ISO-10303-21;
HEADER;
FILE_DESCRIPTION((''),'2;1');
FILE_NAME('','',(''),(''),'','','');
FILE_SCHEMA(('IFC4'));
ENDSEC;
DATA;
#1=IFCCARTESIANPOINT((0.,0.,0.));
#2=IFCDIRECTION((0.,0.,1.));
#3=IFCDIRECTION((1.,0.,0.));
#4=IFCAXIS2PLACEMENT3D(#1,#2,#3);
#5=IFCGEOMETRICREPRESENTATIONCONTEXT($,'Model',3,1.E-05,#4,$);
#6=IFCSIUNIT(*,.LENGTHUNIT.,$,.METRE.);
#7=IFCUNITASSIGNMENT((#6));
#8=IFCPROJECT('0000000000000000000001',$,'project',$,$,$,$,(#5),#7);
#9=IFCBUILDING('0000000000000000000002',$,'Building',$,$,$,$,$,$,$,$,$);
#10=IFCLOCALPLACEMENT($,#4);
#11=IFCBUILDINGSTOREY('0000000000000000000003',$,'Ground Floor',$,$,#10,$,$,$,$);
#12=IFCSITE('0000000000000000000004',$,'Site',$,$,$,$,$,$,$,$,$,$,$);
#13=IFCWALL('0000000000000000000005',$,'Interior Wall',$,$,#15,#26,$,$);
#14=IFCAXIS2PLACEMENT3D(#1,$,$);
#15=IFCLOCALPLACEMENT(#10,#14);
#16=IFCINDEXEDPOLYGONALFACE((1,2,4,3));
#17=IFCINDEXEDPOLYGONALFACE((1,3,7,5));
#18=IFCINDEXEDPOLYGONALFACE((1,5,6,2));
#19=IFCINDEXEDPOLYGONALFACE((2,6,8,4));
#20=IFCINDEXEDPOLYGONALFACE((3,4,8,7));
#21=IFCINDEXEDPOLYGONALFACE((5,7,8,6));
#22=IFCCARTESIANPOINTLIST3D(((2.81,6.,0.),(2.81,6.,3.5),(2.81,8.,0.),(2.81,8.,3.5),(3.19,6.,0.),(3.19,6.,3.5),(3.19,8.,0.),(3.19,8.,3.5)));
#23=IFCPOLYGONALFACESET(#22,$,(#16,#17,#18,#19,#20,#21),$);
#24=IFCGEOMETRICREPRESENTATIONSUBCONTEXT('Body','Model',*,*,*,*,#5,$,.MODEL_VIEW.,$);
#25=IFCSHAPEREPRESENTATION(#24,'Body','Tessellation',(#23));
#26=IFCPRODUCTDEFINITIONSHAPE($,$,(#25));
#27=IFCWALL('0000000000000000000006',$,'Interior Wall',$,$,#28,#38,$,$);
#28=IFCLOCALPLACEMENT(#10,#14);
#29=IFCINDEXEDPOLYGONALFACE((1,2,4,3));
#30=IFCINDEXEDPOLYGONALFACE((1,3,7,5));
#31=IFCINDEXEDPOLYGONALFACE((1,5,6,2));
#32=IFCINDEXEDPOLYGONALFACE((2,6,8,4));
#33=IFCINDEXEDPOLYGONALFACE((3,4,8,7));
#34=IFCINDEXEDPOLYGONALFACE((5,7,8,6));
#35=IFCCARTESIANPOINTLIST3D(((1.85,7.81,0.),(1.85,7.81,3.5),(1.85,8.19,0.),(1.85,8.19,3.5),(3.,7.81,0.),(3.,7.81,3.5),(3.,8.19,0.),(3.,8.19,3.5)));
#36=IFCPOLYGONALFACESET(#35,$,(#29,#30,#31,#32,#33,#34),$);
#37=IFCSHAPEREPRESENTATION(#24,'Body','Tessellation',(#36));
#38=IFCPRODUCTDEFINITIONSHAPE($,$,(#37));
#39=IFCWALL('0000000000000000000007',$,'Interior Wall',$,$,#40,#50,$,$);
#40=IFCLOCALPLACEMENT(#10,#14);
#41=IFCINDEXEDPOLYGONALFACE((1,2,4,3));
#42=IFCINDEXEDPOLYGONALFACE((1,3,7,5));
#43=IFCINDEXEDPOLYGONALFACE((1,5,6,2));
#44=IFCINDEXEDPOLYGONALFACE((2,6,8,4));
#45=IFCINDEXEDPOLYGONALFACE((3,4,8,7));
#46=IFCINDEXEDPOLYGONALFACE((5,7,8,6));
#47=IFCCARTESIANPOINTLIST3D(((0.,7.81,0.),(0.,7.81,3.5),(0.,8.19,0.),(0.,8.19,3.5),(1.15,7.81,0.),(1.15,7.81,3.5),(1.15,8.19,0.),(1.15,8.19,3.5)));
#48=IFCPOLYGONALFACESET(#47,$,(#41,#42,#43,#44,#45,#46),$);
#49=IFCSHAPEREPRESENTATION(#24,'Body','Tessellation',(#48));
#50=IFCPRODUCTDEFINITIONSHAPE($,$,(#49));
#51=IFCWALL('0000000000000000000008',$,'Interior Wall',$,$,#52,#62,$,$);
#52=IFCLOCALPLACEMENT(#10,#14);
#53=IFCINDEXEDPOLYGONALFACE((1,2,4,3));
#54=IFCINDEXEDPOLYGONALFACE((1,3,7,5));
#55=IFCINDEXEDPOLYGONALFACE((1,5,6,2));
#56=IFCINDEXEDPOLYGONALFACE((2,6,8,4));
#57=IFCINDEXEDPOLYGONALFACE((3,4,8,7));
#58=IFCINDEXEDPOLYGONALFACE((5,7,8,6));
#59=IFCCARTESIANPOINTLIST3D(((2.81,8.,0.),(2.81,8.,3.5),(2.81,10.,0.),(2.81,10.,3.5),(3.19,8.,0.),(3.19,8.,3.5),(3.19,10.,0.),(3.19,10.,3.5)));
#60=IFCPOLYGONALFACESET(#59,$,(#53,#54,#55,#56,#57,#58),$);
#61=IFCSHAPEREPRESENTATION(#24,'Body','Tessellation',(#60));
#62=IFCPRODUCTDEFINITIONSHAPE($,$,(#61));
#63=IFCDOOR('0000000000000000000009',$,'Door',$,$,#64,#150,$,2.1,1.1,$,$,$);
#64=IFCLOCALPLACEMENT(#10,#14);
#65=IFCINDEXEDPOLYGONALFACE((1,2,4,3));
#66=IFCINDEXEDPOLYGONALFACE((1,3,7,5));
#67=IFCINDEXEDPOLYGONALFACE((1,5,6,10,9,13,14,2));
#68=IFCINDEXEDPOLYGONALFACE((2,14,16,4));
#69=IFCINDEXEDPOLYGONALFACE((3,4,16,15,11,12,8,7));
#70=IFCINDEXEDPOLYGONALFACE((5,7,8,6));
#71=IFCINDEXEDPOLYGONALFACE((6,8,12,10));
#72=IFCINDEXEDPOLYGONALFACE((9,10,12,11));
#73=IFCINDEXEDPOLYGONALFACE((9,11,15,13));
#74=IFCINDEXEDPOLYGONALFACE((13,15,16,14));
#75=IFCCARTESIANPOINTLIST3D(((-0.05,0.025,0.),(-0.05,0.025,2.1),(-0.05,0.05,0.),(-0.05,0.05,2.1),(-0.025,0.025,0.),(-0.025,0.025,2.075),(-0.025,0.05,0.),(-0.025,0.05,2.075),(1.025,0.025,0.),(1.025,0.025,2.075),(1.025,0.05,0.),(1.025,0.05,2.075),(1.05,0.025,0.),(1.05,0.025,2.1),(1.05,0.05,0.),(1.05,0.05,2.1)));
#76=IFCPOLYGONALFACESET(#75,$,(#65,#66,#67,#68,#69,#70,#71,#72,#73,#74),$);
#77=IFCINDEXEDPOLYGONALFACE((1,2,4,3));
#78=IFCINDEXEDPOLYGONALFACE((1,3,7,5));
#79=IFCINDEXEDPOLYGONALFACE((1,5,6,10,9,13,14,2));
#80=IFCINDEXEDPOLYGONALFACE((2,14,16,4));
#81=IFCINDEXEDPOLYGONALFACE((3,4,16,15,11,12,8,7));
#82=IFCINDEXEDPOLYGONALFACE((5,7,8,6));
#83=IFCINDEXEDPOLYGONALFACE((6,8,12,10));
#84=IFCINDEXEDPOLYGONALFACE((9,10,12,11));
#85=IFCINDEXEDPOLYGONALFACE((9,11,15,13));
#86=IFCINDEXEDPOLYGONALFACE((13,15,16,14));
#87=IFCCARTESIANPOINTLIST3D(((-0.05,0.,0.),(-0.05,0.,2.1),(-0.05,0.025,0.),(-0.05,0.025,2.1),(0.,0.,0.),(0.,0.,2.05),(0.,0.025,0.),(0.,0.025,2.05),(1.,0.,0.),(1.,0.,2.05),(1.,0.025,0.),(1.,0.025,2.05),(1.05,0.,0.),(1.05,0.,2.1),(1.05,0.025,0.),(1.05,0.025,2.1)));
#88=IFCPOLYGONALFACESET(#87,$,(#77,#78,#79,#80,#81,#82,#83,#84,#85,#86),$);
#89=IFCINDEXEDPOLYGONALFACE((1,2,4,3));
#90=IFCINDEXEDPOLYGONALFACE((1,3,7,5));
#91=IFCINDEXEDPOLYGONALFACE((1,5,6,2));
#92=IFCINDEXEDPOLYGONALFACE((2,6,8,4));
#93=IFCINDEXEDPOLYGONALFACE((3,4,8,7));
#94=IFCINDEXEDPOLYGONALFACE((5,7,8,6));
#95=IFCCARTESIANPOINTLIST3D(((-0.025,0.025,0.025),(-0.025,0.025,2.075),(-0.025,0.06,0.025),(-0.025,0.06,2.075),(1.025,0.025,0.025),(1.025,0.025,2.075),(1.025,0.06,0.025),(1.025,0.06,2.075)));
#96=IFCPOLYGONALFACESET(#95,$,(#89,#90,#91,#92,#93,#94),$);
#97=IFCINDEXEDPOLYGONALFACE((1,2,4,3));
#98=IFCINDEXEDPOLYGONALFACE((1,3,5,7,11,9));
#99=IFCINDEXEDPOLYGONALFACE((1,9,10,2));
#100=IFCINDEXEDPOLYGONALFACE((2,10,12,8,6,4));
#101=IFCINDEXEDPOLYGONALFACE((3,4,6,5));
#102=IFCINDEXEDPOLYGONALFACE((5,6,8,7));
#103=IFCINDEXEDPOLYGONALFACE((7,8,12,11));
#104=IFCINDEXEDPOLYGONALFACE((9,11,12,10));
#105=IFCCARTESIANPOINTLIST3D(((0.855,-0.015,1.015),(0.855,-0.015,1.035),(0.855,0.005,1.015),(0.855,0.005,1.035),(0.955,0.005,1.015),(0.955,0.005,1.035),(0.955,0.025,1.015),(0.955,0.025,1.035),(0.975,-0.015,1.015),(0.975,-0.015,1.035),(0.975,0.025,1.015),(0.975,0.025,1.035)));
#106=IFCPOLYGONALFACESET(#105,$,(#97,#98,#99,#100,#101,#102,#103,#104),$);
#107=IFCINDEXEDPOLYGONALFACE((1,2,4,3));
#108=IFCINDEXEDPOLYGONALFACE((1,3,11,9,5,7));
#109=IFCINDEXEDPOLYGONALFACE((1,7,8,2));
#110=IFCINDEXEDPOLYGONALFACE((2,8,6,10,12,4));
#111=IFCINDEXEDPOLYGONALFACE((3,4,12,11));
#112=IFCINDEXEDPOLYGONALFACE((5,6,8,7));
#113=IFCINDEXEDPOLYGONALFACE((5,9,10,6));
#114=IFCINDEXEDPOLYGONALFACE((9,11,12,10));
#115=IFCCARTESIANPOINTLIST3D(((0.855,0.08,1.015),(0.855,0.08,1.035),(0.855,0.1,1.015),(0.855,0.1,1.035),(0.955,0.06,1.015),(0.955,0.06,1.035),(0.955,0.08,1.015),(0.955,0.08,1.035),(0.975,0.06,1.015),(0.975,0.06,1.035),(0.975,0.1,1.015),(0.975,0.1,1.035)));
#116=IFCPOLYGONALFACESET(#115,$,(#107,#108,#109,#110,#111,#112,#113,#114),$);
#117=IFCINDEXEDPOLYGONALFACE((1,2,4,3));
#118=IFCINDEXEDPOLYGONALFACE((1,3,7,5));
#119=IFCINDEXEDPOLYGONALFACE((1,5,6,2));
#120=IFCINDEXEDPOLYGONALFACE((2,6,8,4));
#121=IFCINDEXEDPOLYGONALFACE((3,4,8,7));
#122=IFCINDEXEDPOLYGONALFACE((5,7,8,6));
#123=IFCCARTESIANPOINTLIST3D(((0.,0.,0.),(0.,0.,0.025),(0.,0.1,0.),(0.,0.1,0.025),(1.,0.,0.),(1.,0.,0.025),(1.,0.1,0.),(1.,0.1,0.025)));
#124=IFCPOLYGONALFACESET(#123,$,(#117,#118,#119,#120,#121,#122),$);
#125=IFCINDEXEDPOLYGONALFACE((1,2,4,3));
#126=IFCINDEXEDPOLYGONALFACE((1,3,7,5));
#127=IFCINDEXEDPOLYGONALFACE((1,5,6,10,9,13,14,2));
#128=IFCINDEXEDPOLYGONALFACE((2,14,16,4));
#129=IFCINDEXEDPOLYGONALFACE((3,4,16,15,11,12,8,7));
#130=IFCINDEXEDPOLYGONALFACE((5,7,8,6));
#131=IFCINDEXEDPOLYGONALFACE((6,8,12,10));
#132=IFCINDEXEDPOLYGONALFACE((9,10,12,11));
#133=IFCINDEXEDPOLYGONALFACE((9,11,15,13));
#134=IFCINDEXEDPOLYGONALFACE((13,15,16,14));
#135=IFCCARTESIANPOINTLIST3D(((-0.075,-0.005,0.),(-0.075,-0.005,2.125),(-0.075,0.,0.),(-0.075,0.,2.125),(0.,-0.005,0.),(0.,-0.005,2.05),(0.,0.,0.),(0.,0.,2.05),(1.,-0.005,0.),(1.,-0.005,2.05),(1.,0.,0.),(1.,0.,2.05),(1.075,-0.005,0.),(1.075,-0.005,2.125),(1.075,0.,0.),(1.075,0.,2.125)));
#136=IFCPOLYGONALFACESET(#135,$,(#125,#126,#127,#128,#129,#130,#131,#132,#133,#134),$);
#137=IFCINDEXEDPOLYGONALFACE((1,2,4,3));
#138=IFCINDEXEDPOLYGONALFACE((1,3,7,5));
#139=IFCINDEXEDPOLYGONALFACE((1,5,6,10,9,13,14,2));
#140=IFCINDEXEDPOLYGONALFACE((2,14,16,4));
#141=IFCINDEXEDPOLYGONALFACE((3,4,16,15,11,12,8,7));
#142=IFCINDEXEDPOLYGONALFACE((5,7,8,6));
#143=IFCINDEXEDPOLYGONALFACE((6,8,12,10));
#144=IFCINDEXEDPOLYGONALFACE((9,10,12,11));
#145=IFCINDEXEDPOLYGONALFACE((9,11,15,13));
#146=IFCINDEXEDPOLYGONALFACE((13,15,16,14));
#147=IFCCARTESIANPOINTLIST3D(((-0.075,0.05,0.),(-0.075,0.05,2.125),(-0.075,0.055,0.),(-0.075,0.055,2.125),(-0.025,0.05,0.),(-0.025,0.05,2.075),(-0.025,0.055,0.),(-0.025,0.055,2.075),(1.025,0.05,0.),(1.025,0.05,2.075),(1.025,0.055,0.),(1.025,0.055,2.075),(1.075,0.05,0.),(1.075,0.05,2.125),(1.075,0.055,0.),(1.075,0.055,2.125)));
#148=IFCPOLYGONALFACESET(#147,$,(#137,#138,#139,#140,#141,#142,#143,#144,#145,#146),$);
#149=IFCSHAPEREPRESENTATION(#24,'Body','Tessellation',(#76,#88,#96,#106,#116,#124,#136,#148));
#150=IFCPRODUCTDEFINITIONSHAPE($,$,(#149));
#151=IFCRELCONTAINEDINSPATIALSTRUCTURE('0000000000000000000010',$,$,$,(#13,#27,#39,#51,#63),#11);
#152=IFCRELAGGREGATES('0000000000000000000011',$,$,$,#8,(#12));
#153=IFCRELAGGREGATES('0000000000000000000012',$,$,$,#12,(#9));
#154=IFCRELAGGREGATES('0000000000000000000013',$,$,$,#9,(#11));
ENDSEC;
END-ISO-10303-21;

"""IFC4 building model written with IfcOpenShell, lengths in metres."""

from ifc_helpers import new_model, si_unit, frame, origin_with_axes, place, context, subcontext, project, spatial, line, indexed_curve, outline, extrude, element, save


model = new_model("IFC4")

# Units and contexts
model_context = context("Model", 3, precision=1e-05, world=origin_with_axes())
body_context = subcontext(model_context, "Body", "Model", "MODEL_VIEW")
ifc_project = project(units=[si_unit("LENGTHUNIT", "METRE")], contexts=[model_context])

# Site, building, storey
site = spatial("IfcSite", under=ifc_project, Name="Site")
building = spatial("IfcBuilding", under=site, Name="Building")
storey_placement = place(None, origin_with_axes())
storey = spatial("IfcBuildingStorey", under=building, at=storey_placement, Name="Ground Floor")

# Walls
wall_1_placement = place(storey_placement, frame((3.0, 6.0, 0.0), z_axis=(0.0, 0.0, 1.0), x_axis=(0.0, 1.0, 0.0)))
element("IfcWall", 1, at=wall_1_placement, inside=storey, Name="Interior Wall", context=body_context, shape_type="SweptSolid", body=[
    extrude(outline(indexed_curve([(0.0, 0.0), (0.0, 0.38), (2.0, 0.38), (2.0, 0.0), (0.0, 0.0)], self_intersect=False)), frame((0.0, -0.19, 0.0), z_axis=(0.0, 0.0, 1.0), x_axis=(1.0, 0.0, 0.0)), (0.0, 0.0, 1.0), 3.5),
])
for number, where, z_axis, x_axis, name in (
    (2, (3.0, 8.0, 0.0), (0.0, 0.0, 1.0), (-1.0, 0.0, 0.0), "Interior Wall"),
    (3, (1.15, 8.0, 0.0), (0.0, 0.0, 1.0), (-1.0, 0.0, 0.0), "Interior Wall"),
):
    element("IfcWall", number, at=place(storey_placement, frame(where, z_axis=z_axis, x_axis=x_axis)), inside=storey, Name=name, context=body_context, shape_type="SweptSolid", body=[
        extrude(outline(indexed_curve([(0.0, 0.0), (0.0, 0.38), (1.15, 0.38), (1.15, 0.0), (0.0, 0.0)], self_intersect=False)), frame((0.0, -0.19, 0.0), z_axis=(0.0, 0.0, 1.0), x_axis=(1.0, 0.0, 0.0)), (0.0, 0.0, 1.0), 3.5),
    ])
wall_2_placement = place(storey_placement, frame((3.0, 8.0, 0.0), z_axis=(0.0, 0.0, 1.0), x_axis=(0.0, 1.0, 0.0)))
element("IfcWall", 4, at=wall_2_placement, inside=storey, Name="Interior Wall", context=body_context, shape_type="SweptSolid", body=[
    extrude(outline(indexed_curve([(0.0, 0.0), (0.0, 0.38), (2.0, 0.38), (2.0, 0.0), (0.0, 0.0)], self_intersect=False)), frame((0.0, -0.19, 0.0), z_axis=(0.0, 0.0, 1.0), x_axis=(1.0, 0.0, 0.0)), (0.0, 0.0, 1.0), 3.5),
])

# Door
door_1_placement = place(storey_placement, frame((-0.05, 0.0, 0.0), z_axis=(0.0, 0.0, 1.0), x_axis=(1.0, 0.0, 0.0)))
element("IfcDoor", 5, at=door_1_placement, inside=storey, Name="Door", OverallHeight=2.1, OverallWidth=1.1, context=body_context, shape_type="SweptSolid", body=[
    extrude(outline(indexed_curve([(0.0, 0.0), (0.0, 2.1), (1.1, 2.1), (1.1, 0.0), (1.075, 0.0), (1.075, 2.075), (0.025, 2.075), (0.025, 0.0)], segments=[line(1, 2, 3, 4, 5, 6, 7, 8, 1)])), frame((0.0, 0.025, 0.0), z_axis=(0.0, -1.0, 0.0), x_axis=(1.0, 0.0, 0.0)), (0.0, 0.0, -1.0), 0.025),
    extrude(outline(indexed_curve([(0.0, 0.0), (0.0, 2.1), (1.1, 2.1), (1.1, 0.0), (1.05, 0.0), (1.05, 2.05), (0.05, 2.05), (0.05, 0.0)], segments=[line(1, 2, 3, 4, 5, 6, 7, 8, 1)])), frame((0.0, 0.0, 0.0), z_axis=(0.0, -1.0, 0.0), x_axis=(1.0, 0.0, 0.0)), (0.0, 0.0, -1.0), 0.025),
    extrude(outline(indexed_curve([(0.0, 0.0), (1.05, 0.0), (1.05, 0.035), (0.0, 0.035)], segments=[line(1, 2, 3, 4, 1)])), frame((0.025, 0.025, 0.025), z_axis=(0.0, 0.0, 1.0), x_axis=(1.0, 0.0, 0.0)), (0.0, 0.0, 1.0), 2.05),
    extrude(outline(indexed_curve([(0.0, 0.0), (0.0, -0.04), (-0.12, -0.04), (-0.12, -0.02), (-0.02, -0.02), (-0.02, 0.0)], segments=[line(1, 2, 3, 4, 5, 6, 1)])), frame((1.025, 0.025, 1.015), z_axis=(0.0, 0.0, 1.0), x_axis=(1.0, 0.0, 0.0)), (0.0, 0.0, 1.0), 0.02),
    extrude(outline(indexed_curve([(0.0, 0.0), (0.0, 0.04), (-0.12, 0.04), (-0.12, 0.02), (-0.02, 0.02), (-0.02, 0.0)], segments=[line(1, 2, 3, 4, 5, 6, 1)])), frame((1.025, 0.06, 1.015), z_axis=(0.0, 0.0, 1.0), x_axis=(1.0, 0.0, 0.0)), (0.0, 0.0, 1.0), 0.02),
    extrude(outline(indexed_curve([(0.0, 0.0), (1.0, 0.0), (1.0, 0.1), (0.0, 0.1)], segments=[line(1, 2, 3, 4, 1)])), frame((0.05, 0.0, 0.0), z_axis=(0.0, 0.0, 1.0), x_axis=(1.0, 0.0, 0.0)), (0.0, 0.0, 1.0), 0.025),
    extrude(outline(indexed_curve([(0.0, 0.0), (0.0, 2.125), (1.15, 2.125), (1.15, 0.0), (1.075, 0.0), (1.075, 2.05), (0.075, 2.05), (0.075, 0.0)], segments=[line(1, 2, 3, 4, 5, 6, 7, 8, 1)])), frame((-0.025, -0.005, 0.0), z_axis=(0.0, -1.0, 0.0), x_axis=(1.0, 0.0, 0.0)), (0.0, 0.0, -1.0), 0.005),
    extrude(outline(indexed_curve([(0.0, 0.0), (0.0, 2.125), (1.15, 2.125), (1.15, 0.0), (1.1, 0.0), (1.1, 2.075), (0.05, 2.075), (0.05, 0.0)], segments=[line(1, 2, 3, 4, 5, 6, 7, 8, 1)])), frame((-0.025, 0.05, 0.0), z_axis=(0.0, -1.0, 0.0), x_axis=(1.0, 0.0, 0.0)), (0.0, 0.0, -1.0), 0.005),
])

save(model, "model.ifc")
